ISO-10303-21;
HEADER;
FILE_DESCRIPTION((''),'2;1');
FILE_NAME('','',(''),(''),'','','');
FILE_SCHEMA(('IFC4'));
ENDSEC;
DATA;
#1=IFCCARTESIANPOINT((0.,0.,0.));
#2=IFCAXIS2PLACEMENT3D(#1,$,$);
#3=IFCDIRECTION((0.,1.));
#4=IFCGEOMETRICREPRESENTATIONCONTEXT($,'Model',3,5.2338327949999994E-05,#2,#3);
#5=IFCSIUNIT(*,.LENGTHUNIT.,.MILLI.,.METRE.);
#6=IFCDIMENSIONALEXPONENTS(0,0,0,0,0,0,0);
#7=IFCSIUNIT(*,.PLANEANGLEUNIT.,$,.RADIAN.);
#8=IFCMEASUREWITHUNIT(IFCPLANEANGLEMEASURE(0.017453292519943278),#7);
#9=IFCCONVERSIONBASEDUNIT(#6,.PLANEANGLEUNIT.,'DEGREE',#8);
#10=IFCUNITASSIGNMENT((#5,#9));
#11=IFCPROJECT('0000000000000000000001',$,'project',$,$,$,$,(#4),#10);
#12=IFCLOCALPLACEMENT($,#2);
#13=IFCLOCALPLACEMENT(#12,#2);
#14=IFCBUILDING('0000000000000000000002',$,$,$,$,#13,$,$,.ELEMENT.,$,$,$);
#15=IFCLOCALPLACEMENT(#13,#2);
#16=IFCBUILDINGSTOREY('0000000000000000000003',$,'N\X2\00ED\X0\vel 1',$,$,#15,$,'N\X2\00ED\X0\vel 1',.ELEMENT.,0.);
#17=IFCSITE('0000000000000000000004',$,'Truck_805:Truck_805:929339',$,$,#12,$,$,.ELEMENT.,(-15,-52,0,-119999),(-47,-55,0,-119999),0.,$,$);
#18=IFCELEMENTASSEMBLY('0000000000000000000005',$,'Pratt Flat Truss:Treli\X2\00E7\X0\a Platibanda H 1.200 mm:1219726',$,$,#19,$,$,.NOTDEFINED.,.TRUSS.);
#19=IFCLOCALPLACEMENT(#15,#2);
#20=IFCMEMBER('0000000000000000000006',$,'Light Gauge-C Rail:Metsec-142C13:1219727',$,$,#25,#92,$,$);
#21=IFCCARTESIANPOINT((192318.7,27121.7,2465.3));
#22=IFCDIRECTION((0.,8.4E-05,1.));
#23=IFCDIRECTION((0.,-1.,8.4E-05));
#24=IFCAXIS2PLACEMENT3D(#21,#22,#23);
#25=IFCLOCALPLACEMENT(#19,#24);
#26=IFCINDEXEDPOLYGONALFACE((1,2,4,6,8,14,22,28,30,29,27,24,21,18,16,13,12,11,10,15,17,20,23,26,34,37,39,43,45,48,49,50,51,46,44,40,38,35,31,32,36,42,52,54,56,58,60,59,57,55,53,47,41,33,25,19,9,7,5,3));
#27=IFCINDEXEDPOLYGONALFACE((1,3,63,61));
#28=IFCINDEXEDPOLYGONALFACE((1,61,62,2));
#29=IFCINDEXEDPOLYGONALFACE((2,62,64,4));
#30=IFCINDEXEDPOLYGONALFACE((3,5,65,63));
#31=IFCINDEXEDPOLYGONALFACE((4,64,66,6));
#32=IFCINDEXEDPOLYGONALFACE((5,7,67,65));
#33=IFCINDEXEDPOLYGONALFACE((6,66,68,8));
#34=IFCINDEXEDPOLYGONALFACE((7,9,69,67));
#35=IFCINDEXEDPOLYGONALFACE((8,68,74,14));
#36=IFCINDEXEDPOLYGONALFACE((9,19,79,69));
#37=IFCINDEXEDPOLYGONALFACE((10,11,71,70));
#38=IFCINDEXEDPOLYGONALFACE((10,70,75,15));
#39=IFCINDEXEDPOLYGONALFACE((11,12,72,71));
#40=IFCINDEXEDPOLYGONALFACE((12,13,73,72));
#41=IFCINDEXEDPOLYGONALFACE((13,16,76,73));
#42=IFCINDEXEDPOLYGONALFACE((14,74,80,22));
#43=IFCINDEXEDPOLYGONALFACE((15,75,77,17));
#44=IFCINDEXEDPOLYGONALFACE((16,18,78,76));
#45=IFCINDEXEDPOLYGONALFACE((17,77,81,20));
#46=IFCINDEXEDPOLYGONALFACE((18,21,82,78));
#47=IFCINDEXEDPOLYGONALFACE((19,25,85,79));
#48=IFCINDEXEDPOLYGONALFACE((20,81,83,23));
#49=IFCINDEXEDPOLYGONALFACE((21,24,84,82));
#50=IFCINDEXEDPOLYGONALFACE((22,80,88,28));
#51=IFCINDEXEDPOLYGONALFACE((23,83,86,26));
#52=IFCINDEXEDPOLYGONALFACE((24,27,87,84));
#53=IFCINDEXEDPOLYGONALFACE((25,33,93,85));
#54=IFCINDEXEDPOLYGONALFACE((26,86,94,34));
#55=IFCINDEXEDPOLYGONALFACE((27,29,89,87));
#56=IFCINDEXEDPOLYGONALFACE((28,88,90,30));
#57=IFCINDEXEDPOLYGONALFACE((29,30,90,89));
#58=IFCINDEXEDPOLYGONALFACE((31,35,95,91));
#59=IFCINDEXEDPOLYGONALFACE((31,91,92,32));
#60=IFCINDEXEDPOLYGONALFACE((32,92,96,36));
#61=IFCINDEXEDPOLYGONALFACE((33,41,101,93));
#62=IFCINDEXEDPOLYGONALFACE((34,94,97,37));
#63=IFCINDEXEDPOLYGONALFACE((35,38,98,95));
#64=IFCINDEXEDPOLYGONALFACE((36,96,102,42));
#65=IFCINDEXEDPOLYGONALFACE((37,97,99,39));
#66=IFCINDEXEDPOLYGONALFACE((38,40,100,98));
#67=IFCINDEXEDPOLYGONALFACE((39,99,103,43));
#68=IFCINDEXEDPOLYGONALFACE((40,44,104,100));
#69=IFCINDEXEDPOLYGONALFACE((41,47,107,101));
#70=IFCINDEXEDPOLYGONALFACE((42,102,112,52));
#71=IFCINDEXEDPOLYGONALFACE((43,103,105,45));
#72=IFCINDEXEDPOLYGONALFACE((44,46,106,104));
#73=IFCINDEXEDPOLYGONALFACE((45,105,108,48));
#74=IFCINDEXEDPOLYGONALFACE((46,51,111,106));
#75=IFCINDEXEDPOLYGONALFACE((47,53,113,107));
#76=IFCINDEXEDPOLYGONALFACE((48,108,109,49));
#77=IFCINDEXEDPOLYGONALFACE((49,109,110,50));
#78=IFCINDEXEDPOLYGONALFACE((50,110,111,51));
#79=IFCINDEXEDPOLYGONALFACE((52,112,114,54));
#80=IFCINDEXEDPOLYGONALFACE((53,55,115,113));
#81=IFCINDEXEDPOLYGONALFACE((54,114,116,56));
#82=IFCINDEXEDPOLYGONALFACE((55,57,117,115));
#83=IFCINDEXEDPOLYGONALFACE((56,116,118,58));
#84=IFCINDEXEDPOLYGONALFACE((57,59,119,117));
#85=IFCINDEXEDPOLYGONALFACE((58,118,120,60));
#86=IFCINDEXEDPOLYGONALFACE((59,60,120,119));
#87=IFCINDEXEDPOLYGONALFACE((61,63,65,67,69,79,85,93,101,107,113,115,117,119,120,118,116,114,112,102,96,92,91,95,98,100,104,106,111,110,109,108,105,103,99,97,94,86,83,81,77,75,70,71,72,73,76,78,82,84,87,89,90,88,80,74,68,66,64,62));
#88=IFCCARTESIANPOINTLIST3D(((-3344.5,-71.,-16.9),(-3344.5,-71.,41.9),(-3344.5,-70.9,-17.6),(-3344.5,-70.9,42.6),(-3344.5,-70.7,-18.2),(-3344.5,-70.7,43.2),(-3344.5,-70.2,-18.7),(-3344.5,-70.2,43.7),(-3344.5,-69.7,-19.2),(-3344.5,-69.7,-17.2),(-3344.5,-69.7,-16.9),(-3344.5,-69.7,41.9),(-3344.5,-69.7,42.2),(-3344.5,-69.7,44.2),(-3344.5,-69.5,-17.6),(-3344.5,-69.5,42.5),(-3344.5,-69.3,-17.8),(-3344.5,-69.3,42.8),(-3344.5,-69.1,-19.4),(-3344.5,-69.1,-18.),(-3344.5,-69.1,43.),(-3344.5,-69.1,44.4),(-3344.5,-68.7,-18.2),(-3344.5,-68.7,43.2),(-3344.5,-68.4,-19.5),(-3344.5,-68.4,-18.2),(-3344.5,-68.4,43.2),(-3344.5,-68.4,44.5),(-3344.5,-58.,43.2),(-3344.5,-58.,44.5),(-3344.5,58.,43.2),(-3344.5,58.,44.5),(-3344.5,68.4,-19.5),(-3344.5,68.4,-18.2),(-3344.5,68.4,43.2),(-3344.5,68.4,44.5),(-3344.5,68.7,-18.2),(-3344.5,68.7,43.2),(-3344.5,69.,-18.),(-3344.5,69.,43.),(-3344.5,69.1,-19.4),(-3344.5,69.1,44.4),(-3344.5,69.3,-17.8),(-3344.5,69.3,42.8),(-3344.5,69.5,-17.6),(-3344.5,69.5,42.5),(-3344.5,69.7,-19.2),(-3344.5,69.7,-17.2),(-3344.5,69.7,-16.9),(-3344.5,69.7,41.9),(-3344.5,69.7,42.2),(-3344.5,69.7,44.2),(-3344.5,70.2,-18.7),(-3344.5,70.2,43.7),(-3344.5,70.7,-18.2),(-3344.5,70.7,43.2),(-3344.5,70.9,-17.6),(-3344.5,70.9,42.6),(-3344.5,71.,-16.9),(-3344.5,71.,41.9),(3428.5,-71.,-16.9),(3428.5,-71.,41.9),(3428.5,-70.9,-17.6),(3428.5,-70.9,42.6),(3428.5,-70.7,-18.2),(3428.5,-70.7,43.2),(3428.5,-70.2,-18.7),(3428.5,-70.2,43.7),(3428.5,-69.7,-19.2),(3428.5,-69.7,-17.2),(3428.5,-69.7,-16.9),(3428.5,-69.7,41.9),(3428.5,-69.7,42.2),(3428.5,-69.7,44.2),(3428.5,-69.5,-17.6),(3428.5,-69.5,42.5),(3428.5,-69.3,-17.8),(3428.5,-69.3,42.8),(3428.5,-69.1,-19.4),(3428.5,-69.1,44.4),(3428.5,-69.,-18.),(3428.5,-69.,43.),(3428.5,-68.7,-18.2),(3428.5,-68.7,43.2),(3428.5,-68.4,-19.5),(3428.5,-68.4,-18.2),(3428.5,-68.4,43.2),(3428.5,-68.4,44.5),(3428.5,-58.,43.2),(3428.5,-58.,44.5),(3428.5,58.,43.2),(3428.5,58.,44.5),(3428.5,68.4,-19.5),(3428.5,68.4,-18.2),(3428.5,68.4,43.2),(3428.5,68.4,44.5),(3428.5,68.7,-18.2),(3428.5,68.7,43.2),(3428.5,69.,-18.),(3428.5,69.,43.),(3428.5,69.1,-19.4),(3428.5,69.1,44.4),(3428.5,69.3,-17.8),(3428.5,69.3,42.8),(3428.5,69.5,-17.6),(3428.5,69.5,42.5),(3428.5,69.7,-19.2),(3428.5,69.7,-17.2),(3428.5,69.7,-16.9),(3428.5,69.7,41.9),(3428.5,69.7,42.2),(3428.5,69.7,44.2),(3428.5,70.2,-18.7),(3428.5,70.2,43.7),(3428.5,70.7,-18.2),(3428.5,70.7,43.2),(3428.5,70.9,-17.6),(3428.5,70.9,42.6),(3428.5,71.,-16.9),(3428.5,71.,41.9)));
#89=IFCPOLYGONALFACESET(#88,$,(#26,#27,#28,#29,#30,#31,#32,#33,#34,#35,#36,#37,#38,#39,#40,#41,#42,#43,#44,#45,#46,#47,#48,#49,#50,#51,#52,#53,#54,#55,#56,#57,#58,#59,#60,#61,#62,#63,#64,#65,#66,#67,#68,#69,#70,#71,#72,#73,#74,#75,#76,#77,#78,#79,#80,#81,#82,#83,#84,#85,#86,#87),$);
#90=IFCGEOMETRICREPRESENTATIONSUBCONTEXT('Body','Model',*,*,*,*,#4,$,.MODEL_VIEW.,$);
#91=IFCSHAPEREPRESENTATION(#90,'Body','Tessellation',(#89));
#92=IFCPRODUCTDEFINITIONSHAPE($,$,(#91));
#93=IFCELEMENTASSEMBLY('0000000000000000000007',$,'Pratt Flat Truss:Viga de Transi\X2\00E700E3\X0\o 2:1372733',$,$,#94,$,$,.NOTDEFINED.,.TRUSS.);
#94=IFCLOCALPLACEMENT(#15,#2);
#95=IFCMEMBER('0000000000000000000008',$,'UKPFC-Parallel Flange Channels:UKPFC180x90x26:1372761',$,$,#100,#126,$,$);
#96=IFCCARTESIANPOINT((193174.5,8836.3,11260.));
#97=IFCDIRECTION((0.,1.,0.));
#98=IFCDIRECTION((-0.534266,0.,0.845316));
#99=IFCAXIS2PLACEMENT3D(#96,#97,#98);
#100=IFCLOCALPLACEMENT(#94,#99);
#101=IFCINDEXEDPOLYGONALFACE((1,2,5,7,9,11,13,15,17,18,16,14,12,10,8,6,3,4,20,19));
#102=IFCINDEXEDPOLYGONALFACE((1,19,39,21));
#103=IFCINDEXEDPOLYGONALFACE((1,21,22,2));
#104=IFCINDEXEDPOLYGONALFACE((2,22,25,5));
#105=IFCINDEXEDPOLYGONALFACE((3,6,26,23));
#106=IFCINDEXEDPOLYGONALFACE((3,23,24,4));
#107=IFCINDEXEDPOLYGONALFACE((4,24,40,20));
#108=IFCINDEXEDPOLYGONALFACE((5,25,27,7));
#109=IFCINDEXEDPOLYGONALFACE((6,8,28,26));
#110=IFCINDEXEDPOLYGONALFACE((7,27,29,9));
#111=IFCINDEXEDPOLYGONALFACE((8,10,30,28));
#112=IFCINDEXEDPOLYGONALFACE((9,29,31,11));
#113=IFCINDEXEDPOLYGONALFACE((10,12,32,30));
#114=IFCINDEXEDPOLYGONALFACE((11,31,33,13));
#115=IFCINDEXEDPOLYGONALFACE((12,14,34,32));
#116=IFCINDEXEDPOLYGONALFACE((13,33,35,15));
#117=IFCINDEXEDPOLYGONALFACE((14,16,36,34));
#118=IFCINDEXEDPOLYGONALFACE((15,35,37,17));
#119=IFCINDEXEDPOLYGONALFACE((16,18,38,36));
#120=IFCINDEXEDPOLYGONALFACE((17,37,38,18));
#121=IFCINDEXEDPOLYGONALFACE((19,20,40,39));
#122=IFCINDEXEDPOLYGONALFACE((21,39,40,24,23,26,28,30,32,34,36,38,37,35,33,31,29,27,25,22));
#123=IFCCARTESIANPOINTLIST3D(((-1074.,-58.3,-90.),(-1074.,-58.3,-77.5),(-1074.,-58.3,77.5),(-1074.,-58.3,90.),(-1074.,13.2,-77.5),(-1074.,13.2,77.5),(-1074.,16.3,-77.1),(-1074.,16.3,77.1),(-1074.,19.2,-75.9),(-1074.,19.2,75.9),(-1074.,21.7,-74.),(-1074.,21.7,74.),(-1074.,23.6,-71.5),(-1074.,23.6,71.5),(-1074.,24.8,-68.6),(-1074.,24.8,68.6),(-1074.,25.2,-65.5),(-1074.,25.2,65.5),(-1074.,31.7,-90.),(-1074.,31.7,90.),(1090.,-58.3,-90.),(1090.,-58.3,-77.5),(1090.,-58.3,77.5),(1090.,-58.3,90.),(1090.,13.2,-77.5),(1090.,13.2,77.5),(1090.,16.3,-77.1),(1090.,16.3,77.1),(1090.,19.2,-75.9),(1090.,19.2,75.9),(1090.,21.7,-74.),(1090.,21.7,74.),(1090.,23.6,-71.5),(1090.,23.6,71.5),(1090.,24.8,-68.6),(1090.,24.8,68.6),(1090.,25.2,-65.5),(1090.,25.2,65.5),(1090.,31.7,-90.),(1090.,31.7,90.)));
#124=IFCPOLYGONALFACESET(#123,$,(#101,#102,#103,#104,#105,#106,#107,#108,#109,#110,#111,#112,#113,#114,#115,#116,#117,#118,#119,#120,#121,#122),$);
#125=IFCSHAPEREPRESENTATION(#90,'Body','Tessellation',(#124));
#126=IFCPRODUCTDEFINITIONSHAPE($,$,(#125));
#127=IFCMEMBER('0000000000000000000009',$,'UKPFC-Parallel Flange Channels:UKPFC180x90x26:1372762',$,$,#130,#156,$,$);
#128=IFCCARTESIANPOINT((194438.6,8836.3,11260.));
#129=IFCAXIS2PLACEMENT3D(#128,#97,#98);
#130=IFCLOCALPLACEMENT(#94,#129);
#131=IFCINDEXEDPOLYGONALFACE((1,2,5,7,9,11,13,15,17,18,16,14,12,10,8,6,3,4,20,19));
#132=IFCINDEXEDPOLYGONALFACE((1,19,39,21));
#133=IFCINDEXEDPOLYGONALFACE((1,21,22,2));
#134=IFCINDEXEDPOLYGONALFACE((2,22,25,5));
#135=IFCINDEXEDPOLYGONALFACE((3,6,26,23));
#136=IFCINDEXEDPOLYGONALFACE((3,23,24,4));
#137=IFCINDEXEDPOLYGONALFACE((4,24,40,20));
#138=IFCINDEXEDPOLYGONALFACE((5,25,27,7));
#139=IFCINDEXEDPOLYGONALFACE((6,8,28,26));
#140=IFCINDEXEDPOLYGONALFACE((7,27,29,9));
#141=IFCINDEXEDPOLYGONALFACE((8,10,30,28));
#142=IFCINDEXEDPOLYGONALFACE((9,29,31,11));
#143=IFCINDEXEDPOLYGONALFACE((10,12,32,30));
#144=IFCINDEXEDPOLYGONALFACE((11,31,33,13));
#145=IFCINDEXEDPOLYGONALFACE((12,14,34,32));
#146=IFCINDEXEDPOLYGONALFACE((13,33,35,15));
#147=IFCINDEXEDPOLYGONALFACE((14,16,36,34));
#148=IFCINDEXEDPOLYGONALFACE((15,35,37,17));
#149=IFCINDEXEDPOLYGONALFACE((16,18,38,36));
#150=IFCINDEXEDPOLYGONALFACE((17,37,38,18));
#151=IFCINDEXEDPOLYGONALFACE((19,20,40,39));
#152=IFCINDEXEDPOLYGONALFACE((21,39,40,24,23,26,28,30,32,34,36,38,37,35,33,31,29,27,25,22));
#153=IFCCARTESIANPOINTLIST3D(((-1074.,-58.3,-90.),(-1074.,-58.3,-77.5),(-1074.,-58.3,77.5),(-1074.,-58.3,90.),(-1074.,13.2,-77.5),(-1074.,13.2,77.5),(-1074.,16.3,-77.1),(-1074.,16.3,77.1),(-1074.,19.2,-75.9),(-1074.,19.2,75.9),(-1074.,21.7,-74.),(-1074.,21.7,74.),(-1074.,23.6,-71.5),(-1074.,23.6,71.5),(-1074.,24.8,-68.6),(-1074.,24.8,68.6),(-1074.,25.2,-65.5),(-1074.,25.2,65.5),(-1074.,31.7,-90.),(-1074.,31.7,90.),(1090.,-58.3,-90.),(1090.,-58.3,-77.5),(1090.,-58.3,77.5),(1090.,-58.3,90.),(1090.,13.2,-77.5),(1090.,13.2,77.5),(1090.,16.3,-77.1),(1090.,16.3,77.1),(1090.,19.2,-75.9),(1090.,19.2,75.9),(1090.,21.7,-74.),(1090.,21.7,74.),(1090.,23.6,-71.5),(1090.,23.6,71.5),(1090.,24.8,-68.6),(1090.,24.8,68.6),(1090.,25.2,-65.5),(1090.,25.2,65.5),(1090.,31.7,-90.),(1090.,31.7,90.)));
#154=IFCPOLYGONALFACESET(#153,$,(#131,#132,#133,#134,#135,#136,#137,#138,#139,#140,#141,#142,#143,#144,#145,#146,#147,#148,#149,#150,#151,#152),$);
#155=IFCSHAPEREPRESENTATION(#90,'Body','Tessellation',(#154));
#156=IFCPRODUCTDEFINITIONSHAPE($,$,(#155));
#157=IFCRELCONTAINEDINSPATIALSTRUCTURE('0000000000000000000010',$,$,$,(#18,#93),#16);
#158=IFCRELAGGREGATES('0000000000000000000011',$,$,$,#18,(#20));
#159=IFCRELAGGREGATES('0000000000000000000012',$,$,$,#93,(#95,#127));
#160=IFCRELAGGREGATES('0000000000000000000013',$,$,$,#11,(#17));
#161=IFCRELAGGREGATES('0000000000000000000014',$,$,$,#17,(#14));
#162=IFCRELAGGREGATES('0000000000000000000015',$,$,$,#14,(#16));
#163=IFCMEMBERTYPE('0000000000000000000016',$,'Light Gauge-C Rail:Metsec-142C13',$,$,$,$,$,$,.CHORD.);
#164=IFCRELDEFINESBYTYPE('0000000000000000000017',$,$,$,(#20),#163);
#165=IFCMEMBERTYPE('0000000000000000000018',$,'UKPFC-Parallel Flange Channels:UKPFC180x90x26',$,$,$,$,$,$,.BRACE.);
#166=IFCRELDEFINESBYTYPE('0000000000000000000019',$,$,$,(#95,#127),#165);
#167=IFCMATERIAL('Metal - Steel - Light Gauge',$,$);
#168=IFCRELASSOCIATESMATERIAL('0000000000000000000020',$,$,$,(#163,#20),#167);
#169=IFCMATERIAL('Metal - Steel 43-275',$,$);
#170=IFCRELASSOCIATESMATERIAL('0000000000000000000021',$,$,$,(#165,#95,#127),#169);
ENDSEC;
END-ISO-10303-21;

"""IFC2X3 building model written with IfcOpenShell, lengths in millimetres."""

from ifc_helpers import new_model, entity, si_unit, converted_unit, direction, frame, frame_2d, origin, place, context, subcontext, project, spatial, polyline, circle_curve, parameter, trimmed, segment, composite_curve, outline, extrude, source, transform, mapped, material, type_object, type_shapes, element, aggregate, save


model = new_model("IFC2X3")

# Units and contexts
model_context = context("Model", 3, precision=5.2338327949999994e-05, world=origin(), true_north=direction((0.0, 1.0)))
body_context = subcontext(model_context, "Body", "Model", "MODEL_VIEW")
ifc_project = project(units=[si_unit("LENGTHUNIT", "METRE", prefix="MILLI"), converted_unit("PLANEANGLEUNIT", "DEGREE", entity("IfcPlaneAngleMeasure", 0.017453292519943278), si_unit("PLANEANGLEUNIT", "RADIAN"), dimensions=[0, 0, 0, 0, 0, 0, 0])], contexts=[model_context])

# Site, building, storey
site_placement = place(None, origin())
site = spatial("IfcSite", under=ifc_project, at=site_placement, Name="Truck_805:Truck_805:929339", CompositionType="ELEMENT", RefLatitude=(-15, -52, 0, -119999), RefLongitude=(-47, -55, 0, -119999), RefElevation=0.0)
building_placement = place(site_placement, origin())
building = spatial("IfcBuilding", under=site, at=building_placement, CompositionType="ELEMENT")
storey_placement = place(building_placement, origin())
storey = spatial("IfcBuildingStorey", under=building, at=storey_placement, Name="Nível 1", LongName="Nível 1", CompositionType="ELEMENT", Elevation=0.0)

# Element assemblies, members
assembly_1_placement = place(storey_placement, origin())
assembly_1 = element("IfcElementAssembly", 1, at=assembly_1_placement, inside=storey, Name="Pratt Flat Truss:Treliça Platibanda H 1.200 mm:1219726", AssemblyPlace="NOTDEFINED", PredefinedType="TRUSS")
ifc_material_1 = material(Name="Metal - Steel - Light Gauge")
member_type_1 = type_object("IfcMemberType", Name="Light Gauge-C Rail:Metsec-142C13", PredefinedType="CHORD", material=ifc_material_1)
shared_shape_1 = source(origin(), body_context, "Body", "SweptSolid", [
    extrude(outline(composite_curve([segment(polyline([(-23.1, -71.0), (35.7, -71.0)]), True, "CONTINUOUS"), segment(trimmed(circle_curve(frame_2d((35.7, -68.4), x_axis=(0.0, -1.0)), 2.6), [parameter(0.0)], [parameter(90.0)], True, "PARAMETER"), True, "CONTINUOUS"), segment(polyline([(38.3, -68.4), (38.3, 68.4)]), True, "CONTINUOUS"), segment(trimmed(circle_curve(frame_2d((35.7, 68.4), x_axis=(1.0, 0.0)), 2.6), [parameter(0.0)], [parameter(90.0)], True, "PARAMETER"), True, "CONTINUOUS"), segment(polyline([(35.7, 71.0), (-23.1, 71.0)]), True, "CONTINUOUS"), segment(trimmed(circle_curve(frame_2d((-23.1, 68.4), x_axis=(0.0, 1.0)), 2.6), [parameter(0.0)], [parameter(90.0)], True, "PARAMETER"), True, "CONTINUOUS"), segment(polyline([(-25.7, 68.4), (-25.7, 58.0)]), True, "CONTINUOUS"), segment(polyline([(-25.7, 58.0), (-24.4, 58.0)]), True, "CONTINUOUS"), segment(polyline([(-24.4, 58.0), (-24.4, 68.4)]), True, "CONTINUOUS"), segment(trimmed(circle_curve(frame_2d((-23.1, 68.4), x_axis=(-1.0, 0.0)), 1.3), [parameter(270.0)], [parameter(0.0)], True, "PARAMETER"), False, "CONTINUOUS"), segment(polyline([(-23.1, 69.7), (35.7, 69.7)]), True, "CONTINUOUS"), segment(trimmed(circle_curve(frame_2d((35.7, 68.4), x_axis=(0.0, 1.0)), 1.3), [parameter(270.0)], [parameter(0.0)], True, "PARAMETER"), False, "CONTINUOUS"), segment(polyline([(37.0, 68.4), (37.0, -68.4)]), True, "CONTINUOUS"), segment(trimmed(circle_curve(frame_2d((35.7, -68.4), x_axis=(1.0, 0.0)), 1.3), [parameter(270.0)], [parameter(0.0)], True, "PARAMETER"), False, "CONTINUOUS"), segment(polyline([(35.7, -69.7), (-23.1, -69.7)]), True, "CONTINUOUS"), segment(trimmed(circle_curve(frame_2d((-23.1, -68.4), x_axis=(0.0, -1.0)), 1.3), [parameter(270.0)], [parameter(0.0)], True, "PARAMETER"), False, "CONTINUOUS"), segment(polyline([(-24.4, -68.4), (-24.4, -58.0)]), True, "CONTINUOUS"), segment(polyline([(-24.4, -58.0), (-25.7, -58.0)]), True, "CONTINUOUS"), segment(polyline([(-25.7, -58.0), (-25.7, -68.4)]), True, "CONTINUOUS"), segment(trimmed(circle_curve(frame_2d((-23.1, -68.4), x_axis=(-1.0, 0.0)), 2.6), [parameter(0.0)], [parameter(90.0)], True, "PARAMETER"), True, "CONTINUOUS")], self_intersect=False)), frame((-3344.5, 0.0, 18.8), z_axis=(1.0, 0.0, 0.0), x_axis=(0.0, 0.0, -1.0)), (0.0, 0.0, 1.0), 6773.0),
])
type_shapes(member_type_1, [shared_shape_1])
member_1_placement = place(assembly_1_placement, frame((192318.7, 27121.7, 2465.3), z_axis=(0.0, 0.000084, 1.0), x_axis=(0.0, -1.0, 0.000084)))
member_1 = element("IfcMember", 2, at=member_1_placement, type_object=member_type_1, material=ifc_material_1, Name="Light Gauge-C Rail:Metsec-142C13:1219727", context=body_context, shape_type="MappedRepresentation", body=[
    mapped(shared_shape_1, transform((0.0, 0.0, 0.0), scale=1.0)),
])
aggregate(assembly_1, [member_1])
assembly_2_placement = place(storey_placement, origin())
assembly_2 = element("IfcElementAssembly", 3, at=assembly_2_placement, inside=storey, Name="Pratt Flat Truss:Viga de Transição 2:1372733", AssemblyPlace="NOTDEFINED", PredefinedType="TRUSS")
ifc_material_2 = material(Name="Metal - Steel 43-275")
member_type_2 = type_object("IfcMemberType", Name="UKPFC-Parallel Flange Channels:UKPFC180x90x26", PredefinedType="BRACE", material=ifc_material_2)
shared_shape_2 = source(origin(), body_context, "Body", "SweptSolid", [
    extrude(outline(composite_curve([segment(polyline([(-90.0, -49.0), (-77.5, -49.0)]), True, "CONTINUOUS"), segment(polyline([(-77.5, -49.0), (-77.5, 22.5)]), True, "CONTINUOUS"), segment(trimmed(circle_curve(frame_2d((-65.5, 22.5), x_axis=(-1.0, 0.0)), 12.0), [parameter(270.0)], [parameter(0.0)], True, "PARAMETER"), False, "CONTINUOUS"), segment(polyline([(-65.5, 34.5), (65.5, 34.5)]), True, "CONTINUOUS"), segment(trimmed(circle_curve(frame_2d((65.5, 22.5), x_axis=(0.0, 1.0)), 12.0), [parameter(270.0)], [parameter(0.0)], True, "PARAMETER"), False, "CONTINUOUS"), segment(polyline([(77.5, 22.5), (77.5, -49.0)]), True, "CONTINUOUS"), segment(polyline([(77.5, -49.0), (90.0, -49.0)]), True, "CONTINUOUS"), segment(polyline([(90.0, -49.0), (90.0, 41.0)]), True, "CONTINUOUS"), segment(polyline([(90.0, 41.0), (-90.0, 41.0)]), True, "CONTINUOUS"), segment(polyline([(-90.0, 41.0), (-90.0, -49.0)]), True, "CONTINUOUS")], self_intersect=False)), frame((-1074.0, -9.3, 0.0), z_axis=(1.0, 0.0, 0.0), x_axis=(0.0, 0.0, -1.0)), (0.0, 0.0, 1.0), 2164.0),
])
type_shapes(member_type_2, [shared_shape_2])
member_2_placement = place(assembly_2_placement, frame((193174.5, 8836.3, 11260.0), z_axis=(0.0, 1.0, 0.0), x_axis=(-0.534266, 0.0, 0.845316)))
member_2 = element("IfcMember", 4, at=member_2_placement, type_object=member_type_2, material=ifc_material_2, Name="UKPFC-Parallel Flange Channels:UKPFC180x90x26:1372761", context=body_context, shape_type="MappedRepresentation", body=[
    mapped(shared_shape_2, transform((0.0, 0.0, 0.0), scale=1.0)),
])
member_3_placement = place(assembly_2_placement, frame((194438.6, 8836.3, 11260.0), z_axis=(0.0, 1.0, 0.0), x_axis=(-0.534266, 0.0, 0.845316)))
member_3 = element("IfcMember", 5, at=member_3_placement, type_object=member_type_2, material=ifc_material_2, Name="UKPFC-Parallel Flange Channels:UKPFC180x90x26:1372762", context=body_context, shape_type="MappedRepresentation", body=[
    mapped(shared_shape_2, transform((0.0, 0.0, 0.0), scale=1.0)),
])
aggregate(assembly_2, [member_2, member_3])

save(model, "model.ifc")
